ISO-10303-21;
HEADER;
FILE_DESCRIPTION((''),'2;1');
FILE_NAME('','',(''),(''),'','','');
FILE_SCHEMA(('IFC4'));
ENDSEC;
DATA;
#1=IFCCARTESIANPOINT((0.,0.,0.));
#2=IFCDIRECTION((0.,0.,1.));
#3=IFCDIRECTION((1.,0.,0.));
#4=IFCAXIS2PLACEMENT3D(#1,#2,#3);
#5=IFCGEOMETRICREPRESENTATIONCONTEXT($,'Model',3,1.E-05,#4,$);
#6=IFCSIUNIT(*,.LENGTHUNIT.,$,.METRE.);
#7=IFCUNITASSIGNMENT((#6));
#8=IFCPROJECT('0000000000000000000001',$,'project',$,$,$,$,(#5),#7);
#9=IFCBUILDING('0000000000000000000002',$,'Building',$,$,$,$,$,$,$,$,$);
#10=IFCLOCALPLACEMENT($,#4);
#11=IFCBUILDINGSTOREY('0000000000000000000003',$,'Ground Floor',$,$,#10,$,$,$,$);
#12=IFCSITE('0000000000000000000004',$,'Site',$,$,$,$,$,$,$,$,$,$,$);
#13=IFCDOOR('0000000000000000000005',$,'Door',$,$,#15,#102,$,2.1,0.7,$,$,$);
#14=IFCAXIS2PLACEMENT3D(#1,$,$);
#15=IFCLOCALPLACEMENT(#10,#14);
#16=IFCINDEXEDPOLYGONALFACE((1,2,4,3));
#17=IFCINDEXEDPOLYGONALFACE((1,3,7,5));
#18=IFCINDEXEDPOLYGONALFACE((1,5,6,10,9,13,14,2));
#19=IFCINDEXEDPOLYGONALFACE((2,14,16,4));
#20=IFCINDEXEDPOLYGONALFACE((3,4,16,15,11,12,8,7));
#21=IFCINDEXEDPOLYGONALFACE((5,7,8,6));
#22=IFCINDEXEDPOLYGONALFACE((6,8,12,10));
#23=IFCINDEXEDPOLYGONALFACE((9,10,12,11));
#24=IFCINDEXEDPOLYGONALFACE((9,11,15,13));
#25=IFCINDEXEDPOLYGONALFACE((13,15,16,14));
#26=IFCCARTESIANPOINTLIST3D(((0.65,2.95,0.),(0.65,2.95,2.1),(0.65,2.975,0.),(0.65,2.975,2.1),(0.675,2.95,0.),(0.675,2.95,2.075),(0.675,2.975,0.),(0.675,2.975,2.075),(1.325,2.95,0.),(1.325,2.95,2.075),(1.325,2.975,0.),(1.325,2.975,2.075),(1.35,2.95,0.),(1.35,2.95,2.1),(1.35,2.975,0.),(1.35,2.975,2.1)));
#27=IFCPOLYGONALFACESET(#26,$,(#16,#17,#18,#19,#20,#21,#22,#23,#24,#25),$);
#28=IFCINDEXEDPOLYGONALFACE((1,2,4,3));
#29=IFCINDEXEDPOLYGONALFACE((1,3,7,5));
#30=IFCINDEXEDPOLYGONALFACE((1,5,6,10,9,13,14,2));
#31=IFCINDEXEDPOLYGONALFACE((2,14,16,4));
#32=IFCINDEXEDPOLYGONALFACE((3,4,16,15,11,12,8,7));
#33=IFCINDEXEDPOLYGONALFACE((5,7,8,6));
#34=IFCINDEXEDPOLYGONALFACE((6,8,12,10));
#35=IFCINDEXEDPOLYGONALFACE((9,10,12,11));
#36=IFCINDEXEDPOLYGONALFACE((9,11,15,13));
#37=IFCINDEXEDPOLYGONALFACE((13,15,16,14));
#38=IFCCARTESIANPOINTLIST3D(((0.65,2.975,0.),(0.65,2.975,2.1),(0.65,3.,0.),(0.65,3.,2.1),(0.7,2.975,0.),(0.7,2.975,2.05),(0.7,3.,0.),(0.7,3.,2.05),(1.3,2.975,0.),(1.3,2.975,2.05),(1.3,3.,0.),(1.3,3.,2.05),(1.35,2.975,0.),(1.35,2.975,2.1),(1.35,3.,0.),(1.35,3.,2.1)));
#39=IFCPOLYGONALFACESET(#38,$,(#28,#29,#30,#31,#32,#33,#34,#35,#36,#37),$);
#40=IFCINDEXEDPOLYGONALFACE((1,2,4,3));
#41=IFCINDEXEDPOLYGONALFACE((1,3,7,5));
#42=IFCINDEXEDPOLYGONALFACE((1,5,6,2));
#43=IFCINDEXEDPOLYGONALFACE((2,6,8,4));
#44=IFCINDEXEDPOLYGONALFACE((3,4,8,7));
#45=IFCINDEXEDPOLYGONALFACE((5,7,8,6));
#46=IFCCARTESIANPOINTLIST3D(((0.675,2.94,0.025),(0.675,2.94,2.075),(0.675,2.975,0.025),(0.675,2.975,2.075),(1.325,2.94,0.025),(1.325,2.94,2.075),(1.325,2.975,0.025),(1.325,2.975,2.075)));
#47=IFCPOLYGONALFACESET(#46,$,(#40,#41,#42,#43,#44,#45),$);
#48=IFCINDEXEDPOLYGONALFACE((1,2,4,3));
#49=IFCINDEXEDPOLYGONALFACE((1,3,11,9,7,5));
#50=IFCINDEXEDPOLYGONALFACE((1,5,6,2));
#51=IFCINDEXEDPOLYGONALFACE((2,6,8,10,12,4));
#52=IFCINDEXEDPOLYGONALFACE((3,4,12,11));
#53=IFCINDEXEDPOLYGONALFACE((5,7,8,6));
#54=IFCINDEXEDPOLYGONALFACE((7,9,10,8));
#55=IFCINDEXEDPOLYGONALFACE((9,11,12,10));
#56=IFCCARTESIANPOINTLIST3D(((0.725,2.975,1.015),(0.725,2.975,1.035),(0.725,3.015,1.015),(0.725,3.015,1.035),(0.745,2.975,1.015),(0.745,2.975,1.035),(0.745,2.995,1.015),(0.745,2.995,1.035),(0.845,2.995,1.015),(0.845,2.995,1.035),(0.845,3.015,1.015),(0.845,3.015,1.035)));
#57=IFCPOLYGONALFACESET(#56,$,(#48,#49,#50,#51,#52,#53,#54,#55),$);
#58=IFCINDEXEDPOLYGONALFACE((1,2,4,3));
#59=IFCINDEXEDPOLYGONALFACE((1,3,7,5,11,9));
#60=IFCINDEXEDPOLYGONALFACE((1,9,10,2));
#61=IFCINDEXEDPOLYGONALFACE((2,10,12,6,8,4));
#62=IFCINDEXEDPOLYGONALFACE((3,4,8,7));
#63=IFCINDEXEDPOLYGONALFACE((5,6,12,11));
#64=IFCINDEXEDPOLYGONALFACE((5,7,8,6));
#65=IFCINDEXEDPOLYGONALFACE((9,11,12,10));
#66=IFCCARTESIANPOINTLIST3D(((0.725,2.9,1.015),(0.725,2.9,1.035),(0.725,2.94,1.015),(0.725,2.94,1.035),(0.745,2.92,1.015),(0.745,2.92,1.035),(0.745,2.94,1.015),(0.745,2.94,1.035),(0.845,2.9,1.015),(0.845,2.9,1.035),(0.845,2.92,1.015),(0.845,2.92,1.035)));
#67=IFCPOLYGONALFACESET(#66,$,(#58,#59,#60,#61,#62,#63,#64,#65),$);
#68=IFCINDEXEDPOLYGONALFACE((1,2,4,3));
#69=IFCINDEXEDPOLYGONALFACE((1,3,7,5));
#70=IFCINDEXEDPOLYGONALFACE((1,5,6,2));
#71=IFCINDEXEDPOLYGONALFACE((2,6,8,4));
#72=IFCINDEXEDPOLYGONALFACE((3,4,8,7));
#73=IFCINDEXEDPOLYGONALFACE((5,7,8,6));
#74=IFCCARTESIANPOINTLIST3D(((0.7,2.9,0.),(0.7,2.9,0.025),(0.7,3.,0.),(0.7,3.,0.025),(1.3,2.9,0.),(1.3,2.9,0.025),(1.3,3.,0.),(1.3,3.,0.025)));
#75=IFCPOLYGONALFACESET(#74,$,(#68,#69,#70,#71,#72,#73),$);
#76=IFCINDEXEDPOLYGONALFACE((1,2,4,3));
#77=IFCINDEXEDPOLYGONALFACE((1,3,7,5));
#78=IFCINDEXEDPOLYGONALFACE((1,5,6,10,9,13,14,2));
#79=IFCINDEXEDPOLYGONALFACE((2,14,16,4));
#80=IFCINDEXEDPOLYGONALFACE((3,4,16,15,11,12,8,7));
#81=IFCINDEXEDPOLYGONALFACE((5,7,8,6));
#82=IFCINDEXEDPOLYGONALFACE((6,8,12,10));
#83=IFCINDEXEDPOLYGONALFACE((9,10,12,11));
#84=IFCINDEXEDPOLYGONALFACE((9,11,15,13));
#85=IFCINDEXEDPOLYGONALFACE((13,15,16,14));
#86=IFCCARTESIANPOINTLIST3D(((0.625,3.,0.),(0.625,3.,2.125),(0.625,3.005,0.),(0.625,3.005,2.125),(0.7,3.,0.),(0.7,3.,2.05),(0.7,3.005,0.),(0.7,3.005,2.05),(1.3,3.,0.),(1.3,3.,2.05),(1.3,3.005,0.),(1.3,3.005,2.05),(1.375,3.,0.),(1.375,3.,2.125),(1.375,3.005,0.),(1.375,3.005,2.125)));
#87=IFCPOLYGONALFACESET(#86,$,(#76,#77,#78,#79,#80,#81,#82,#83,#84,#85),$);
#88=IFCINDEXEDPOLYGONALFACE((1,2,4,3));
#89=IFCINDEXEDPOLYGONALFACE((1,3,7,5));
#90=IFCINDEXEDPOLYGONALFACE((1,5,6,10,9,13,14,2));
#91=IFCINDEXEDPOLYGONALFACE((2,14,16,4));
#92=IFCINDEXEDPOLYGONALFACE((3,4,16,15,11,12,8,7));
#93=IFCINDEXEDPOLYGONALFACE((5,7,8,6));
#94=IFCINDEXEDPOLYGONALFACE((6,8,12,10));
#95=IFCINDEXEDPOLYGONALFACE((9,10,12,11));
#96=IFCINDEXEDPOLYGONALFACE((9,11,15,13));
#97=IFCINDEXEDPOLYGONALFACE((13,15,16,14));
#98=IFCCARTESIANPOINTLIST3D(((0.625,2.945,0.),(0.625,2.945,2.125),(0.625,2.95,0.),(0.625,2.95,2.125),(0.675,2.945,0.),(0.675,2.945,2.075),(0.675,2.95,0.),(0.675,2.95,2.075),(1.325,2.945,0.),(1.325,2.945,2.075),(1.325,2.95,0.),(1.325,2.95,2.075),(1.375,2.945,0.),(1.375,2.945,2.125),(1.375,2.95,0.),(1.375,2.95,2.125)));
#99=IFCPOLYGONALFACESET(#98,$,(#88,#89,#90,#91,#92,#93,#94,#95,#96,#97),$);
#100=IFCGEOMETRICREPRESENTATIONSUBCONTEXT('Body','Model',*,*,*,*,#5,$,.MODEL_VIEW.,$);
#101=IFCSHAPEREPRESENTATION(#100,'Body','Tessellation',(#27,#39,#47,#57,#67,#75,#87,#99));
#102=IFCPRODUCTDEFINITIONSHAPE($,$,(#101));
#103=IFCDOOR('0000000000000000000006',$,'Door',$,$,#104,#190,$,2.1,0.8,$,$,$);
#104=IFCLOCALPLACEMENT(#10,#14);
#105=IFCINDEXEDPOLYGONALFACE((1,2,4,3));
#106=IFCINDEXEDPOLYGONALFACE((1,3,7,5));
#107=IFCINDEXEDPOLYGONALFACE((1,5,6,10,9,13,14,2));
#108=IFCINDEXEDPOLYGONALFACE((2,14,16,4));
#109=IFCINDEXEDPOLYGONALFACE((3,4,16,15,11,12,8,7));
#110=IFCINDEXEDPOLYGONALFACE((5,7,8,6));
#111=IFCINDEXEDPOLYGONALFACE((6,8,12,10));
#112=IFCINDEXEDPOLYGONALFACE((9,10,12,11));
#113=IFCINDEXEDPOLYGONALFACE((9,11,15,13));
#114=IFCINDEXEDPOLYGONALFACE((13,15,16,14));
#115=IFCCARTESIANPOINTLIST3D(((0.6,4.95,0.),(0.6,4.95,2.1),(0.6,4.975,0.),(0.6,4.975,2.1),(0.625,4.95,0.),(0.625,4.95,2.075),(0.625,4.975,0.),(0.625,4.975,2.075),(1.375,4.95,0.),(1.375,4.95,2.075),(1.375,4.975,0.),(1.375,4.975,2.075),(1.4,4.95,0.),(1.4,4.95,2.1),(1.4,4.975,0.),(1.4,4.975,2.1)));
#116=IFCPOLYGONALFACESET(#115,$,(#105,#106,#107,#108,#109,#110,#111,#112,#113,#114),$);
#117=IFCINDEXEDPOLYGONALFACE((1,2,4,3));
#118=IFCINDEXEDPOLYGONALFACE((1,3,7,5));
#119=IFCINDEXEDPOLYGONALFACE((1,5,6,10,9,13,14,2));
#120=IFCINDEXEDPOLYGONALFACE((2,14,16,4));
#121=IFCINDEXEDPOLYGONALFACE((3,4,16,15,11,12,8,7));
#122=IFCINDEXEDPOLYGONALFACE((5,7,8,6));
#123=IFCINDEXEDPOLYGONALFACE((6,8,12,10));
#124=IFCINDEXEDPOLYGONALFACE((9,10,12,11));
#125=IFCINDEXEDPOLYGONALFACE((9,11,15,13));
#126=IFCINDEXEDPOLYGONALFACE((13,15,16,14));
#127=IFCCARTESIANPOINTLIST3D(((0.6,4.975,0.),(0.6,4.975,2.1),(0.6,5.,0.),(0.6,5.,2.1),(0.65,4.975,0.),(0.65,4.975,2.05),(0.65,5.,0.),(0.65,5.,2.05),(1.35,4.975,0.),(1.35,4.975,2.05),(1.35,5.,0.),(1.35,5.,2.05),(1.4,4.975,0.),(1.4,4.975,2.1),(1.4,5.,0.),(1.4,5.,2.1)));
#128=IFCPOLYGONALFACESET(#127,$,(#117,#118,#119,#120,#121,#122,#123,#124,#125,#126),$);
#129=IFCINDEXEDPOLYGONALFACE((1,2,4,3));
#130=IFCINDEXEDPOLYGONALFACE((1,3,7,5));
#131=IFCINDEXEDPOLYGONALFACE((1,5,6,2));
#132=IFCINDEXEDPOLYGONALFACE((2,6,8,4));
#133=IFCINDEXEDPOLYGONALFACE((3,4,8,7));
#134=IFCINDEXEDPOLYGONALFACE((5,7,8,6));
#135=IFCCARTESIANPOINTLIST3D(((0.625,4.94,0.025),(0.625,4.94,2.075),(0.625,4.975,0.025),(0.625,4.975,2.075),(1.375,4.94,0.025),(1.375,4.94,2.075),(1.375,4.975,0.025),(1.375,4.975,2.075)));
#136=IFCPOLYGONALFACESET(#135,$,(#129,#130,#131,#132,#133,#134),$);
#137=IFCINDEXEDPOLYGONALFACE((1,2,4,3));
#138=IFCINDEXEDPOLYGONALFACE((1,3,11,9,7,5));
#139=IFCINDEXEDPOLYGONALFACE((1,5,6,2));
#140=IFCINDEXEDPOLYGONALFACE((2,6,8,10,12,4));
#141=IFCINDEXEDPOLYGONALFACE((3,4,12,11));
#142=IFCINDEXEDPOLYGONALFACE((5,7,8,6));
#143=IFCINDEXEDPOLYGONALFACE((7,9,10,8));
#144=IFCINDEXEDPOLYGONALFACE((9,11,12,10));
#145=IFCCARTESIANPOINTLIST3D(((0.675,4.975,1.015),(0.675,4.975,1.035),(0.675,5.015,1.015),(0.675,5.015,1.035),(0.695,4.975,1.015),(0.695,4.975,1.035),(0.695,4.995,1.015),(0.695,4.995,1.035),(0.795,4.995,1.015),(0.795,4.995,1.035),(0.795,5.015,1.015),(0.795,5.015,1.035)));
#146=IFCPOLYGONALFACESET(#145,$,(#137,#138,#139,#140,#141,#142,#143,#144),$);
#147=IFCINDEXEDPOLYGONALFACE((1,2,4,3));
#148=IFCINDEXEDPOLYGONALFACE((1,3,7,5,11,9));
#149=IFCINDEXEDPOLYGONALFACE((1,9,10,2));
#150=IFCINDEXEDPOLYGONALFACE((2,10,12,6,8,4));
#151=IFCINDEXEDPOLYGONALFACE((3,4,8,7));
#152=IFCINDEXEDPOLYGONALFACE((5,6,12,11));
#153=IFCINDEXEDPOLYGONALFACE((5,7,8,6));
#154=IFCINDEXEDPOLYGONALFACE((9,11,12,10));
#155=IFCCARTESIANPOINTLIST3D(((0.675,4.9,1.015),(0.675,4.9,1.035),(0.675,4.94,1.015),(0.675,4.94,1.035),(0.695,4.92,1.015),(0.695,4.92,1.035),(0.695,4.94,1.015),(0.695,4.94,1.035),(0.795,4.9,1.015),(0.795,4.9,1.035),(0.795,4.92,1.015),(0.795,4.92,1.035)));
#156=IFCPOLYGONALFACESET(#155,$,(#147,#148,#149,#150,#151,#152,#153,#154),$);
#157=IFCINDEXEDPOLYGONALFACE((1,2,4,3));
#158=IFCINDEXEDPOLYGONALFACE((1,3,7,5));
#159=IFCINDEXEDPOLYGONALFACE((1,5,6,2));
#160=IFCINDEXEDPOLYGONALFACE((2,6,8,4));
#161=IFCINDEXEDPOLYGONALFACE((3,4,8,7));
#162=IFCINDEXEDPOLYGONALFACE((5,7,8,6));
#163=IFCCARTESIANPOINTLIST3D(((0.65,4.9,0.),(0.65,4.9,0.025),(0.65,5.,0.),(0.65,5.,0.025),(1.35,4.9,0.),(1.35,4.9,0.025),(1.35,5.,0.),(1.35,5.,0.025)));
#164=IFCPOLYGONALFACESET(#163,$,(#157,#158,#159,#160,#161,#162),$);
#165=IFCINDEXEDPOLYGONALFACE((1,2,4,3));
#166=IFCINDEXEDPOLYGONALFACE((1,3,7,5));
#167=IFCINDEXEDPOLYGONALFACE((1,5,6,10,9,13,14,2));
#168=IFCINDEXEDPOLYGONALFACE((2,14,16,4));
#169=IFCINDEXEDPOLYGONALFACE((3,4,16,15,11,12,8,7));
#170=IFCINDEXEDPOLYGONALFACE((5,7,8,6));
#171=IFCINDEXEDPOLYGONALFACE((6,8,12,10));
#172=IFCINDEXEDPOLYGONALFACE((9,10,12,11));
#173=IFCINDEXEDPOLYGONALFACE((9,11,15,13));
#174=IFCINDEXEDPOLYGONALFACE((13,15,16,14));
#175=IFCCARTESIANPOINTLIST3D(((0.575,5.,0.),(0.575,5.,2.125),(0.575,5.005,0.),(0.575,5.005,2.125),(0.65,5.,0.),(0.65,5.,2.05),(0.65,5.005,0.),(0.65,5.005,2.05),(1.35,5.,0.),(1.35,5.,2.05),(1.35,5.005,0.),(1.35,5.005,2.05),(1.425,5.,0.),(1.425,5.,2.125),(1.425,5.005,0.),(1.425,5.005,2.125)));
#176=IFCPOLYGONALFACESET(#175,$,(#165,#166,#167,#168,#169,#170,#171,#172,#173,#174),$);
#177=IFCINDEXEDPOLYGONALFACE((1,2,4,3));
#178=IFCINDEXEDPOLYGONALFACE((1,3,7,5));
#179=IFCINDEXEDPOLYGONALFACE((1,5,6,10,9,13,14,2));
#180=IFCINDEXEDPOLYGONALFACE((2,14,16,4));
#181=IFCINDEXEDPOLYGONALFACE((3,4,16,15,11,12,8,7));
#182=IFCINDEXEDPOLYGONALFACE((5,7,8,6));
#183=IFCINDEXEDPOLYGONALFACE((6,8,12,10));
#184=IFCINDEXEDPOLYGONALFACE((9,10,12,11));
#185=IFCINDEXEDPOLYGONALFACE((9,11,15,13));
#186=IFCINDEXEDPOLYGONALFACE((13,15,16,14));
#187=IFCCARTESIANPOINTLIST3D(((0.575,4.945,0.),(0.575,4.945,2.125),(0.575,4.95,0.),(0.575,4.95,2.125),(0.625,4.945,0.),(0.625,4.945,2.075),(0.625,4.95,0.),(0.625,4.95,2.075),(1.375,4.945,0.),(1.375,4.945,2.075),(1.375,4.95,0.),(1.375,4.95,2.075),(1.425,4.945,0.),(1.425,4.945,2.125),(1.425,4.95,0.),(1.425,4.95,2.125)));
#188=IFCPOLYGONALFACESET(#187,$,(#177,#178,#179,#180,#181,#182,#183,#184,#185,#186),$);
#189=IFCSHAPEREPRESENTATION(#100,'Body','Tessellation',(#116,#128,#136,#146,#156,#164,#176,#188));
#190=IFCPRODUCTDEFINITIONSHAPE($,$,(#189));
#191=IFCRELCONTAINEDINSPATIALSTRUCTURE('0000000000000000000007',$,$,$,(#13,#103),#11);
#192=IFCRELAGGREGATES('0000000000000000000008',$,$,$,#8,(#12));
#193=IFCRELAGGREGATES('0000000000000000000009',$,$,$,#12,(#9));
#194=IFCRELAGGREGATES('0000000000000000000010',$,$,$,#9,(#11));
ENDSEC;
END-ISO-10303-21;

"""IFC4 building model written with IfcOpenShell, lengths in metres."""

from ifc_helpers import new_model, si_unit, frame, origin_with_axes, place, context, subcontext, project, spatial, line, indexed_curve, outline, extrude, element, save


model = new_model("IFC4")

# Units and contexts
model_context = context("Model", 3, precision=1e-05, world=origin_with_axes())
body_context = subcontext(model_context, "Body", "Model", "MODEL_VIEW")
ifc_project = project(units=[si_unit("LENGTHUNIT", "METRE")], contexts=[model_context])

# Site, building, storey
site = spatial("IfcSite", under=ifc_project, Name="Site")
building = spatial("IfcBuilding", under=site, Name="Building")
storey_placement = place(None, origin_with_axes())
storey = spatial("IfcBuildingStorey", under=building, at=storey_placement, Name="Ground Floor")

# Doors
door_1_placement = place(storey_placement, frame((1.35, 3.0, 0.0), z_axis=(0.0, 0.0, 1.0), x_axis=(-1.0, 0.0, 0.0)))
element("IfcDoor", 1, at=door_1_placement, inside=storey, Name="Door", OverallHeight=2.1, OverallWidth=0.7, context=body_context, shape_type="SweptSolid", body=[
    extrude(outline(indexed_curve([(0.0, 0.0), (0.0, 2.1), (0.7, 2.1), (0.7, 0.0), (0.675, 0.0), (0.675, 2.075), (0.025, 2.075), (0.025, 0.0)], segments=[line(1, 2, 3, 4, 5, 6, 7, 8, 1)])), frame((0.0, 0.025, 0.0), z_axis=(0.0, -1.0, 0.0), x_axis=(1.0, 0.0, 0.0)), (0.0, 0.0, -1.0), 0.025),
    extrude(outline(indexed_curve([(0.0, 0.0), (0.0, 2.1), (0.7, 2.1), (0.7, 0.0), (0.65, 0.0), (0.65, 2.05), (0.05, 2.05), (0.05, 0.0)], segments=[line(1, 2, 3, 4, 5, 6, 7, 8, 1)])), frame((0.0, 0.0, 0.0), z_axis=(0.0, -1.0, 0.0), x_axis=(1.0, 0.0, 0.0)), (0.0, 0.0, -1.0), 0.025),
    extrude(outline(indexed_curve([(0.0, 0.0), (0.65, 0.0), (0.65, 0.035), (0.0, 0.035)], segments=[line(1, 2, 3, 4, 1)])), frame((0.025, 0.025, 0.025), z_axis=(0.0, 0.0, 1.0), x_axis=(1.0, 0.0, 0.0)), (0.0, 0.0, 1.0), 2.05),
    extrude(outline(indexed_curve([(0.0, 0.0), (0.0, -0.04), (-0.12, -0.04), (-0.12, -0.02), (-0.02, -0.02), (-0.02, 0.0)], segments=[line(1, 2, 3, 4, 5, 6, 1)])), frame((0.625, 0.025, 1.015), z_axis=(0.0, 0.0, 1.0), x_axis=(1.0, 0.0, 0.0)), (0.0, 0.0, 1.0), 0.02),
    extrude(outline(indexed_curve([(0.0, 0.0), (0.0, 0.04), (-0.12, 0.04), (-0.12, 0.02), (-0.02, 0.02), (-0.02, 0.0)], segments=[line(1, 2, 3, 4, 5, 6, 1)])), frame((0.625, 0.06, 1.015), z_axis=(0.0, 0.0, 1.0), x_axis=(1.0, 0.0, 0.0)), (0.0, 0.0, 1.0), 0.02),
    extrude(outline(indexed_curve([(0.0, 0.0), (0.6, 0.0), (0.6, 0.1), (0.0, 0.1)], segments=[line(1, 2, 3, 4, 1)])), frame((0.05, 0.0, 0.0), z_axis=(0.0, 0.0, 1.0), x_axis=(1.0, 0.0, 0.0)), (0.0, 0.0, 1.0), 0.025),
    extrude(outline(indexed_curve([(0.0, 0.0), (0.0, 2.125), (0.75, 2.125), (0.75, 0.0), (0.675, 0.0), (0.675, 2.05), (0.075, 2.05), (0.075, 0.0)], segments=[line(1, 2, 3, 4, 5, 6, 7, 8, 1)])), frame((-0.025, -0.005, 0.0), z_axis=(0.0, -1.0, 0.0), x_axis=(1.0, 0.0, 0.0)), (0.0, 0.0, -1.0), 0.005),
    extrude(outline(indexed_curve([(0.0, 0.0), (0.0, 2.125), (0.75, 2.125), (0.75, 0.0), (0.7, 0.0), (0.7, 2.075), (0.05, 2.075), (0.05, 0.0)], segments=[line(1, 2, 3, 4, 5, 6, 7, 8, 1)])), frame((-0.025, 0.05, 0.0), z_axis=(0.0, -1.0, 0.0), x_axis=(1.0, 0.0, 0.0)), (0.0, 0.0, -1.0), 0.005),
])
door_2_placement = place(storey_placement, frame((1.4, 5.0, 0.0), z_axis=(0.0, 0.0, 1.0), x_axis=(-1.0, 0.0, 0.0)))
element("IfcDoor", 2, at=door_2_placement, inside=storey, Name="Door", OverallHeight=2.1, OverallWidth=0.8, context=body_context, shape_type="SweptSolid", body=[
    extrude(outline(indexed_curve([(0.0, 0.0), (0.0, 2.1), (0.8, 2.1), (0.8, 0.0), (0.775, 0.0), (0.775, 2.075), (0.025, 2.075), (0.025, 0.0)], segments=[line(1, 2, 3, 4, 5, 6, 7, 8, 1)])), frame((0.0, 0.025, 0.0), z_axis=(0.0, -1.0, 0.0), x_axis=(1.0, 0.0, 0.0)), (0.0, 0.0, -1.0), 0.025),
    extrude(outline(indexed_curve([(0.0, 0.0), (0.0, 2.1), (0.8, 2.1), (0.8, 0.0), (0.75, 0.0), (0.75, 2.05), (0.05, 2.05), (0.05, 0.0)], segments=[line(1, 2, 3, 4, 5, 6, 7, 8, 1)])), frame((0.0, 0.0, 0.0), z_axis=(0.0, -1.0, 0.0), x_axis=(1.0, 0.0, 0.0)), (0.0, 0.0, -1.0), 0.025),
    extrude(outline(indexed_curve([(0.0, 0.0), (0.75, 0.0), (0.75, 0.035), (0.0, 0.035)], segments=[line(1, 2, 3, 4, 1)])), frame((0.025, 0.025, 0.025), z_axis=(0.0, 0.0, 1.0), x_axis=(1.0, 0.0, 0.0)), (0.0, 0.0, 1.0), 2.05),
    extrude(outline(indexed_curve([(0.0, 0.0), (0.0, -0.04), (-0.12, -0.04), (-0.12, -0.02), (-0.02, -0.02), (-0.02, 0.0)], segments=[line(1, 2, 3, 4, 5, 6, 1)])), frame((0.725, 0.025, 1.015), z_axis=(0.0, 0.0, 1.0), x_axis=(1.0, 0.0, 0.0)), (0.0, 0.0, 1.0), 0.02),
    extrude(outline(indexed_curve([(0.0, 0.0), (0.0, 0.04), (-0.12, 0.04), (-0.12, 0.02), (-0.02, 0.02), (-0.02, 0.0)], segments=[line(1, 2, 3, 4, 5, 6, 1)])), frame((0.725, 0.06, 1.015), z_axis=(0.0, 0.0, 1.0), x_axis=(1.0, 0.0, 0.0)), (0.0, 0.0, 1.0), 0.02),
    extrude(outline(indexed_curve([(0.0, 0.0), (0.7, 0.0), (0.7, 0.1), (0.0, 0.1)], segments=[line(1, 2, 3, 4, 1)])), frame((0.05, 0.0, 0.0), z_axis=(0.0, 0.0, 1.0), x_axis=(1.0, 0.0, 0.0)), (0.0, 0.0, 1.0), 0.025),
    extrude(outline(indexed_curve([(0.0, 0.0), (0.0, 2.125), (0.85, 2.125), (0.85, 0.0), (0.775, 0.0), (0.775, 2.05), (0.075, 2.05), (0.075, 0.0)], segments=[line(1, 2, 3, 4, 5, 6, 7, 8, 1)])), frame((-0.025, -0.005, 0.0), z_axis=(0.0, -1.0, 0.0), x_axis=(1.0, 0.0, 0.0)), (0.0, 0.0, -1.0), 0.005),
    extrude(outline(indexed_curve([(0.0, 0.0), (0.0, 2.125), (0.85, 2.125), (0.85, 0.0), (0.8, 0.0), (0.8, 2.075), (0.05, 2.075), (0.05, 0.0)], segments=[line(1, 2, 3, 4, 5, 6, 7, 8, 1)])), frame((-0.025, 0.05, 0.0), z_axis=(0.0, -1.0, 0.0), x_axis=(1.0, 0.0, 0.0)), (0.0, 0.0, -1.0), 0.005),
])

save(model, "model.ifc")
